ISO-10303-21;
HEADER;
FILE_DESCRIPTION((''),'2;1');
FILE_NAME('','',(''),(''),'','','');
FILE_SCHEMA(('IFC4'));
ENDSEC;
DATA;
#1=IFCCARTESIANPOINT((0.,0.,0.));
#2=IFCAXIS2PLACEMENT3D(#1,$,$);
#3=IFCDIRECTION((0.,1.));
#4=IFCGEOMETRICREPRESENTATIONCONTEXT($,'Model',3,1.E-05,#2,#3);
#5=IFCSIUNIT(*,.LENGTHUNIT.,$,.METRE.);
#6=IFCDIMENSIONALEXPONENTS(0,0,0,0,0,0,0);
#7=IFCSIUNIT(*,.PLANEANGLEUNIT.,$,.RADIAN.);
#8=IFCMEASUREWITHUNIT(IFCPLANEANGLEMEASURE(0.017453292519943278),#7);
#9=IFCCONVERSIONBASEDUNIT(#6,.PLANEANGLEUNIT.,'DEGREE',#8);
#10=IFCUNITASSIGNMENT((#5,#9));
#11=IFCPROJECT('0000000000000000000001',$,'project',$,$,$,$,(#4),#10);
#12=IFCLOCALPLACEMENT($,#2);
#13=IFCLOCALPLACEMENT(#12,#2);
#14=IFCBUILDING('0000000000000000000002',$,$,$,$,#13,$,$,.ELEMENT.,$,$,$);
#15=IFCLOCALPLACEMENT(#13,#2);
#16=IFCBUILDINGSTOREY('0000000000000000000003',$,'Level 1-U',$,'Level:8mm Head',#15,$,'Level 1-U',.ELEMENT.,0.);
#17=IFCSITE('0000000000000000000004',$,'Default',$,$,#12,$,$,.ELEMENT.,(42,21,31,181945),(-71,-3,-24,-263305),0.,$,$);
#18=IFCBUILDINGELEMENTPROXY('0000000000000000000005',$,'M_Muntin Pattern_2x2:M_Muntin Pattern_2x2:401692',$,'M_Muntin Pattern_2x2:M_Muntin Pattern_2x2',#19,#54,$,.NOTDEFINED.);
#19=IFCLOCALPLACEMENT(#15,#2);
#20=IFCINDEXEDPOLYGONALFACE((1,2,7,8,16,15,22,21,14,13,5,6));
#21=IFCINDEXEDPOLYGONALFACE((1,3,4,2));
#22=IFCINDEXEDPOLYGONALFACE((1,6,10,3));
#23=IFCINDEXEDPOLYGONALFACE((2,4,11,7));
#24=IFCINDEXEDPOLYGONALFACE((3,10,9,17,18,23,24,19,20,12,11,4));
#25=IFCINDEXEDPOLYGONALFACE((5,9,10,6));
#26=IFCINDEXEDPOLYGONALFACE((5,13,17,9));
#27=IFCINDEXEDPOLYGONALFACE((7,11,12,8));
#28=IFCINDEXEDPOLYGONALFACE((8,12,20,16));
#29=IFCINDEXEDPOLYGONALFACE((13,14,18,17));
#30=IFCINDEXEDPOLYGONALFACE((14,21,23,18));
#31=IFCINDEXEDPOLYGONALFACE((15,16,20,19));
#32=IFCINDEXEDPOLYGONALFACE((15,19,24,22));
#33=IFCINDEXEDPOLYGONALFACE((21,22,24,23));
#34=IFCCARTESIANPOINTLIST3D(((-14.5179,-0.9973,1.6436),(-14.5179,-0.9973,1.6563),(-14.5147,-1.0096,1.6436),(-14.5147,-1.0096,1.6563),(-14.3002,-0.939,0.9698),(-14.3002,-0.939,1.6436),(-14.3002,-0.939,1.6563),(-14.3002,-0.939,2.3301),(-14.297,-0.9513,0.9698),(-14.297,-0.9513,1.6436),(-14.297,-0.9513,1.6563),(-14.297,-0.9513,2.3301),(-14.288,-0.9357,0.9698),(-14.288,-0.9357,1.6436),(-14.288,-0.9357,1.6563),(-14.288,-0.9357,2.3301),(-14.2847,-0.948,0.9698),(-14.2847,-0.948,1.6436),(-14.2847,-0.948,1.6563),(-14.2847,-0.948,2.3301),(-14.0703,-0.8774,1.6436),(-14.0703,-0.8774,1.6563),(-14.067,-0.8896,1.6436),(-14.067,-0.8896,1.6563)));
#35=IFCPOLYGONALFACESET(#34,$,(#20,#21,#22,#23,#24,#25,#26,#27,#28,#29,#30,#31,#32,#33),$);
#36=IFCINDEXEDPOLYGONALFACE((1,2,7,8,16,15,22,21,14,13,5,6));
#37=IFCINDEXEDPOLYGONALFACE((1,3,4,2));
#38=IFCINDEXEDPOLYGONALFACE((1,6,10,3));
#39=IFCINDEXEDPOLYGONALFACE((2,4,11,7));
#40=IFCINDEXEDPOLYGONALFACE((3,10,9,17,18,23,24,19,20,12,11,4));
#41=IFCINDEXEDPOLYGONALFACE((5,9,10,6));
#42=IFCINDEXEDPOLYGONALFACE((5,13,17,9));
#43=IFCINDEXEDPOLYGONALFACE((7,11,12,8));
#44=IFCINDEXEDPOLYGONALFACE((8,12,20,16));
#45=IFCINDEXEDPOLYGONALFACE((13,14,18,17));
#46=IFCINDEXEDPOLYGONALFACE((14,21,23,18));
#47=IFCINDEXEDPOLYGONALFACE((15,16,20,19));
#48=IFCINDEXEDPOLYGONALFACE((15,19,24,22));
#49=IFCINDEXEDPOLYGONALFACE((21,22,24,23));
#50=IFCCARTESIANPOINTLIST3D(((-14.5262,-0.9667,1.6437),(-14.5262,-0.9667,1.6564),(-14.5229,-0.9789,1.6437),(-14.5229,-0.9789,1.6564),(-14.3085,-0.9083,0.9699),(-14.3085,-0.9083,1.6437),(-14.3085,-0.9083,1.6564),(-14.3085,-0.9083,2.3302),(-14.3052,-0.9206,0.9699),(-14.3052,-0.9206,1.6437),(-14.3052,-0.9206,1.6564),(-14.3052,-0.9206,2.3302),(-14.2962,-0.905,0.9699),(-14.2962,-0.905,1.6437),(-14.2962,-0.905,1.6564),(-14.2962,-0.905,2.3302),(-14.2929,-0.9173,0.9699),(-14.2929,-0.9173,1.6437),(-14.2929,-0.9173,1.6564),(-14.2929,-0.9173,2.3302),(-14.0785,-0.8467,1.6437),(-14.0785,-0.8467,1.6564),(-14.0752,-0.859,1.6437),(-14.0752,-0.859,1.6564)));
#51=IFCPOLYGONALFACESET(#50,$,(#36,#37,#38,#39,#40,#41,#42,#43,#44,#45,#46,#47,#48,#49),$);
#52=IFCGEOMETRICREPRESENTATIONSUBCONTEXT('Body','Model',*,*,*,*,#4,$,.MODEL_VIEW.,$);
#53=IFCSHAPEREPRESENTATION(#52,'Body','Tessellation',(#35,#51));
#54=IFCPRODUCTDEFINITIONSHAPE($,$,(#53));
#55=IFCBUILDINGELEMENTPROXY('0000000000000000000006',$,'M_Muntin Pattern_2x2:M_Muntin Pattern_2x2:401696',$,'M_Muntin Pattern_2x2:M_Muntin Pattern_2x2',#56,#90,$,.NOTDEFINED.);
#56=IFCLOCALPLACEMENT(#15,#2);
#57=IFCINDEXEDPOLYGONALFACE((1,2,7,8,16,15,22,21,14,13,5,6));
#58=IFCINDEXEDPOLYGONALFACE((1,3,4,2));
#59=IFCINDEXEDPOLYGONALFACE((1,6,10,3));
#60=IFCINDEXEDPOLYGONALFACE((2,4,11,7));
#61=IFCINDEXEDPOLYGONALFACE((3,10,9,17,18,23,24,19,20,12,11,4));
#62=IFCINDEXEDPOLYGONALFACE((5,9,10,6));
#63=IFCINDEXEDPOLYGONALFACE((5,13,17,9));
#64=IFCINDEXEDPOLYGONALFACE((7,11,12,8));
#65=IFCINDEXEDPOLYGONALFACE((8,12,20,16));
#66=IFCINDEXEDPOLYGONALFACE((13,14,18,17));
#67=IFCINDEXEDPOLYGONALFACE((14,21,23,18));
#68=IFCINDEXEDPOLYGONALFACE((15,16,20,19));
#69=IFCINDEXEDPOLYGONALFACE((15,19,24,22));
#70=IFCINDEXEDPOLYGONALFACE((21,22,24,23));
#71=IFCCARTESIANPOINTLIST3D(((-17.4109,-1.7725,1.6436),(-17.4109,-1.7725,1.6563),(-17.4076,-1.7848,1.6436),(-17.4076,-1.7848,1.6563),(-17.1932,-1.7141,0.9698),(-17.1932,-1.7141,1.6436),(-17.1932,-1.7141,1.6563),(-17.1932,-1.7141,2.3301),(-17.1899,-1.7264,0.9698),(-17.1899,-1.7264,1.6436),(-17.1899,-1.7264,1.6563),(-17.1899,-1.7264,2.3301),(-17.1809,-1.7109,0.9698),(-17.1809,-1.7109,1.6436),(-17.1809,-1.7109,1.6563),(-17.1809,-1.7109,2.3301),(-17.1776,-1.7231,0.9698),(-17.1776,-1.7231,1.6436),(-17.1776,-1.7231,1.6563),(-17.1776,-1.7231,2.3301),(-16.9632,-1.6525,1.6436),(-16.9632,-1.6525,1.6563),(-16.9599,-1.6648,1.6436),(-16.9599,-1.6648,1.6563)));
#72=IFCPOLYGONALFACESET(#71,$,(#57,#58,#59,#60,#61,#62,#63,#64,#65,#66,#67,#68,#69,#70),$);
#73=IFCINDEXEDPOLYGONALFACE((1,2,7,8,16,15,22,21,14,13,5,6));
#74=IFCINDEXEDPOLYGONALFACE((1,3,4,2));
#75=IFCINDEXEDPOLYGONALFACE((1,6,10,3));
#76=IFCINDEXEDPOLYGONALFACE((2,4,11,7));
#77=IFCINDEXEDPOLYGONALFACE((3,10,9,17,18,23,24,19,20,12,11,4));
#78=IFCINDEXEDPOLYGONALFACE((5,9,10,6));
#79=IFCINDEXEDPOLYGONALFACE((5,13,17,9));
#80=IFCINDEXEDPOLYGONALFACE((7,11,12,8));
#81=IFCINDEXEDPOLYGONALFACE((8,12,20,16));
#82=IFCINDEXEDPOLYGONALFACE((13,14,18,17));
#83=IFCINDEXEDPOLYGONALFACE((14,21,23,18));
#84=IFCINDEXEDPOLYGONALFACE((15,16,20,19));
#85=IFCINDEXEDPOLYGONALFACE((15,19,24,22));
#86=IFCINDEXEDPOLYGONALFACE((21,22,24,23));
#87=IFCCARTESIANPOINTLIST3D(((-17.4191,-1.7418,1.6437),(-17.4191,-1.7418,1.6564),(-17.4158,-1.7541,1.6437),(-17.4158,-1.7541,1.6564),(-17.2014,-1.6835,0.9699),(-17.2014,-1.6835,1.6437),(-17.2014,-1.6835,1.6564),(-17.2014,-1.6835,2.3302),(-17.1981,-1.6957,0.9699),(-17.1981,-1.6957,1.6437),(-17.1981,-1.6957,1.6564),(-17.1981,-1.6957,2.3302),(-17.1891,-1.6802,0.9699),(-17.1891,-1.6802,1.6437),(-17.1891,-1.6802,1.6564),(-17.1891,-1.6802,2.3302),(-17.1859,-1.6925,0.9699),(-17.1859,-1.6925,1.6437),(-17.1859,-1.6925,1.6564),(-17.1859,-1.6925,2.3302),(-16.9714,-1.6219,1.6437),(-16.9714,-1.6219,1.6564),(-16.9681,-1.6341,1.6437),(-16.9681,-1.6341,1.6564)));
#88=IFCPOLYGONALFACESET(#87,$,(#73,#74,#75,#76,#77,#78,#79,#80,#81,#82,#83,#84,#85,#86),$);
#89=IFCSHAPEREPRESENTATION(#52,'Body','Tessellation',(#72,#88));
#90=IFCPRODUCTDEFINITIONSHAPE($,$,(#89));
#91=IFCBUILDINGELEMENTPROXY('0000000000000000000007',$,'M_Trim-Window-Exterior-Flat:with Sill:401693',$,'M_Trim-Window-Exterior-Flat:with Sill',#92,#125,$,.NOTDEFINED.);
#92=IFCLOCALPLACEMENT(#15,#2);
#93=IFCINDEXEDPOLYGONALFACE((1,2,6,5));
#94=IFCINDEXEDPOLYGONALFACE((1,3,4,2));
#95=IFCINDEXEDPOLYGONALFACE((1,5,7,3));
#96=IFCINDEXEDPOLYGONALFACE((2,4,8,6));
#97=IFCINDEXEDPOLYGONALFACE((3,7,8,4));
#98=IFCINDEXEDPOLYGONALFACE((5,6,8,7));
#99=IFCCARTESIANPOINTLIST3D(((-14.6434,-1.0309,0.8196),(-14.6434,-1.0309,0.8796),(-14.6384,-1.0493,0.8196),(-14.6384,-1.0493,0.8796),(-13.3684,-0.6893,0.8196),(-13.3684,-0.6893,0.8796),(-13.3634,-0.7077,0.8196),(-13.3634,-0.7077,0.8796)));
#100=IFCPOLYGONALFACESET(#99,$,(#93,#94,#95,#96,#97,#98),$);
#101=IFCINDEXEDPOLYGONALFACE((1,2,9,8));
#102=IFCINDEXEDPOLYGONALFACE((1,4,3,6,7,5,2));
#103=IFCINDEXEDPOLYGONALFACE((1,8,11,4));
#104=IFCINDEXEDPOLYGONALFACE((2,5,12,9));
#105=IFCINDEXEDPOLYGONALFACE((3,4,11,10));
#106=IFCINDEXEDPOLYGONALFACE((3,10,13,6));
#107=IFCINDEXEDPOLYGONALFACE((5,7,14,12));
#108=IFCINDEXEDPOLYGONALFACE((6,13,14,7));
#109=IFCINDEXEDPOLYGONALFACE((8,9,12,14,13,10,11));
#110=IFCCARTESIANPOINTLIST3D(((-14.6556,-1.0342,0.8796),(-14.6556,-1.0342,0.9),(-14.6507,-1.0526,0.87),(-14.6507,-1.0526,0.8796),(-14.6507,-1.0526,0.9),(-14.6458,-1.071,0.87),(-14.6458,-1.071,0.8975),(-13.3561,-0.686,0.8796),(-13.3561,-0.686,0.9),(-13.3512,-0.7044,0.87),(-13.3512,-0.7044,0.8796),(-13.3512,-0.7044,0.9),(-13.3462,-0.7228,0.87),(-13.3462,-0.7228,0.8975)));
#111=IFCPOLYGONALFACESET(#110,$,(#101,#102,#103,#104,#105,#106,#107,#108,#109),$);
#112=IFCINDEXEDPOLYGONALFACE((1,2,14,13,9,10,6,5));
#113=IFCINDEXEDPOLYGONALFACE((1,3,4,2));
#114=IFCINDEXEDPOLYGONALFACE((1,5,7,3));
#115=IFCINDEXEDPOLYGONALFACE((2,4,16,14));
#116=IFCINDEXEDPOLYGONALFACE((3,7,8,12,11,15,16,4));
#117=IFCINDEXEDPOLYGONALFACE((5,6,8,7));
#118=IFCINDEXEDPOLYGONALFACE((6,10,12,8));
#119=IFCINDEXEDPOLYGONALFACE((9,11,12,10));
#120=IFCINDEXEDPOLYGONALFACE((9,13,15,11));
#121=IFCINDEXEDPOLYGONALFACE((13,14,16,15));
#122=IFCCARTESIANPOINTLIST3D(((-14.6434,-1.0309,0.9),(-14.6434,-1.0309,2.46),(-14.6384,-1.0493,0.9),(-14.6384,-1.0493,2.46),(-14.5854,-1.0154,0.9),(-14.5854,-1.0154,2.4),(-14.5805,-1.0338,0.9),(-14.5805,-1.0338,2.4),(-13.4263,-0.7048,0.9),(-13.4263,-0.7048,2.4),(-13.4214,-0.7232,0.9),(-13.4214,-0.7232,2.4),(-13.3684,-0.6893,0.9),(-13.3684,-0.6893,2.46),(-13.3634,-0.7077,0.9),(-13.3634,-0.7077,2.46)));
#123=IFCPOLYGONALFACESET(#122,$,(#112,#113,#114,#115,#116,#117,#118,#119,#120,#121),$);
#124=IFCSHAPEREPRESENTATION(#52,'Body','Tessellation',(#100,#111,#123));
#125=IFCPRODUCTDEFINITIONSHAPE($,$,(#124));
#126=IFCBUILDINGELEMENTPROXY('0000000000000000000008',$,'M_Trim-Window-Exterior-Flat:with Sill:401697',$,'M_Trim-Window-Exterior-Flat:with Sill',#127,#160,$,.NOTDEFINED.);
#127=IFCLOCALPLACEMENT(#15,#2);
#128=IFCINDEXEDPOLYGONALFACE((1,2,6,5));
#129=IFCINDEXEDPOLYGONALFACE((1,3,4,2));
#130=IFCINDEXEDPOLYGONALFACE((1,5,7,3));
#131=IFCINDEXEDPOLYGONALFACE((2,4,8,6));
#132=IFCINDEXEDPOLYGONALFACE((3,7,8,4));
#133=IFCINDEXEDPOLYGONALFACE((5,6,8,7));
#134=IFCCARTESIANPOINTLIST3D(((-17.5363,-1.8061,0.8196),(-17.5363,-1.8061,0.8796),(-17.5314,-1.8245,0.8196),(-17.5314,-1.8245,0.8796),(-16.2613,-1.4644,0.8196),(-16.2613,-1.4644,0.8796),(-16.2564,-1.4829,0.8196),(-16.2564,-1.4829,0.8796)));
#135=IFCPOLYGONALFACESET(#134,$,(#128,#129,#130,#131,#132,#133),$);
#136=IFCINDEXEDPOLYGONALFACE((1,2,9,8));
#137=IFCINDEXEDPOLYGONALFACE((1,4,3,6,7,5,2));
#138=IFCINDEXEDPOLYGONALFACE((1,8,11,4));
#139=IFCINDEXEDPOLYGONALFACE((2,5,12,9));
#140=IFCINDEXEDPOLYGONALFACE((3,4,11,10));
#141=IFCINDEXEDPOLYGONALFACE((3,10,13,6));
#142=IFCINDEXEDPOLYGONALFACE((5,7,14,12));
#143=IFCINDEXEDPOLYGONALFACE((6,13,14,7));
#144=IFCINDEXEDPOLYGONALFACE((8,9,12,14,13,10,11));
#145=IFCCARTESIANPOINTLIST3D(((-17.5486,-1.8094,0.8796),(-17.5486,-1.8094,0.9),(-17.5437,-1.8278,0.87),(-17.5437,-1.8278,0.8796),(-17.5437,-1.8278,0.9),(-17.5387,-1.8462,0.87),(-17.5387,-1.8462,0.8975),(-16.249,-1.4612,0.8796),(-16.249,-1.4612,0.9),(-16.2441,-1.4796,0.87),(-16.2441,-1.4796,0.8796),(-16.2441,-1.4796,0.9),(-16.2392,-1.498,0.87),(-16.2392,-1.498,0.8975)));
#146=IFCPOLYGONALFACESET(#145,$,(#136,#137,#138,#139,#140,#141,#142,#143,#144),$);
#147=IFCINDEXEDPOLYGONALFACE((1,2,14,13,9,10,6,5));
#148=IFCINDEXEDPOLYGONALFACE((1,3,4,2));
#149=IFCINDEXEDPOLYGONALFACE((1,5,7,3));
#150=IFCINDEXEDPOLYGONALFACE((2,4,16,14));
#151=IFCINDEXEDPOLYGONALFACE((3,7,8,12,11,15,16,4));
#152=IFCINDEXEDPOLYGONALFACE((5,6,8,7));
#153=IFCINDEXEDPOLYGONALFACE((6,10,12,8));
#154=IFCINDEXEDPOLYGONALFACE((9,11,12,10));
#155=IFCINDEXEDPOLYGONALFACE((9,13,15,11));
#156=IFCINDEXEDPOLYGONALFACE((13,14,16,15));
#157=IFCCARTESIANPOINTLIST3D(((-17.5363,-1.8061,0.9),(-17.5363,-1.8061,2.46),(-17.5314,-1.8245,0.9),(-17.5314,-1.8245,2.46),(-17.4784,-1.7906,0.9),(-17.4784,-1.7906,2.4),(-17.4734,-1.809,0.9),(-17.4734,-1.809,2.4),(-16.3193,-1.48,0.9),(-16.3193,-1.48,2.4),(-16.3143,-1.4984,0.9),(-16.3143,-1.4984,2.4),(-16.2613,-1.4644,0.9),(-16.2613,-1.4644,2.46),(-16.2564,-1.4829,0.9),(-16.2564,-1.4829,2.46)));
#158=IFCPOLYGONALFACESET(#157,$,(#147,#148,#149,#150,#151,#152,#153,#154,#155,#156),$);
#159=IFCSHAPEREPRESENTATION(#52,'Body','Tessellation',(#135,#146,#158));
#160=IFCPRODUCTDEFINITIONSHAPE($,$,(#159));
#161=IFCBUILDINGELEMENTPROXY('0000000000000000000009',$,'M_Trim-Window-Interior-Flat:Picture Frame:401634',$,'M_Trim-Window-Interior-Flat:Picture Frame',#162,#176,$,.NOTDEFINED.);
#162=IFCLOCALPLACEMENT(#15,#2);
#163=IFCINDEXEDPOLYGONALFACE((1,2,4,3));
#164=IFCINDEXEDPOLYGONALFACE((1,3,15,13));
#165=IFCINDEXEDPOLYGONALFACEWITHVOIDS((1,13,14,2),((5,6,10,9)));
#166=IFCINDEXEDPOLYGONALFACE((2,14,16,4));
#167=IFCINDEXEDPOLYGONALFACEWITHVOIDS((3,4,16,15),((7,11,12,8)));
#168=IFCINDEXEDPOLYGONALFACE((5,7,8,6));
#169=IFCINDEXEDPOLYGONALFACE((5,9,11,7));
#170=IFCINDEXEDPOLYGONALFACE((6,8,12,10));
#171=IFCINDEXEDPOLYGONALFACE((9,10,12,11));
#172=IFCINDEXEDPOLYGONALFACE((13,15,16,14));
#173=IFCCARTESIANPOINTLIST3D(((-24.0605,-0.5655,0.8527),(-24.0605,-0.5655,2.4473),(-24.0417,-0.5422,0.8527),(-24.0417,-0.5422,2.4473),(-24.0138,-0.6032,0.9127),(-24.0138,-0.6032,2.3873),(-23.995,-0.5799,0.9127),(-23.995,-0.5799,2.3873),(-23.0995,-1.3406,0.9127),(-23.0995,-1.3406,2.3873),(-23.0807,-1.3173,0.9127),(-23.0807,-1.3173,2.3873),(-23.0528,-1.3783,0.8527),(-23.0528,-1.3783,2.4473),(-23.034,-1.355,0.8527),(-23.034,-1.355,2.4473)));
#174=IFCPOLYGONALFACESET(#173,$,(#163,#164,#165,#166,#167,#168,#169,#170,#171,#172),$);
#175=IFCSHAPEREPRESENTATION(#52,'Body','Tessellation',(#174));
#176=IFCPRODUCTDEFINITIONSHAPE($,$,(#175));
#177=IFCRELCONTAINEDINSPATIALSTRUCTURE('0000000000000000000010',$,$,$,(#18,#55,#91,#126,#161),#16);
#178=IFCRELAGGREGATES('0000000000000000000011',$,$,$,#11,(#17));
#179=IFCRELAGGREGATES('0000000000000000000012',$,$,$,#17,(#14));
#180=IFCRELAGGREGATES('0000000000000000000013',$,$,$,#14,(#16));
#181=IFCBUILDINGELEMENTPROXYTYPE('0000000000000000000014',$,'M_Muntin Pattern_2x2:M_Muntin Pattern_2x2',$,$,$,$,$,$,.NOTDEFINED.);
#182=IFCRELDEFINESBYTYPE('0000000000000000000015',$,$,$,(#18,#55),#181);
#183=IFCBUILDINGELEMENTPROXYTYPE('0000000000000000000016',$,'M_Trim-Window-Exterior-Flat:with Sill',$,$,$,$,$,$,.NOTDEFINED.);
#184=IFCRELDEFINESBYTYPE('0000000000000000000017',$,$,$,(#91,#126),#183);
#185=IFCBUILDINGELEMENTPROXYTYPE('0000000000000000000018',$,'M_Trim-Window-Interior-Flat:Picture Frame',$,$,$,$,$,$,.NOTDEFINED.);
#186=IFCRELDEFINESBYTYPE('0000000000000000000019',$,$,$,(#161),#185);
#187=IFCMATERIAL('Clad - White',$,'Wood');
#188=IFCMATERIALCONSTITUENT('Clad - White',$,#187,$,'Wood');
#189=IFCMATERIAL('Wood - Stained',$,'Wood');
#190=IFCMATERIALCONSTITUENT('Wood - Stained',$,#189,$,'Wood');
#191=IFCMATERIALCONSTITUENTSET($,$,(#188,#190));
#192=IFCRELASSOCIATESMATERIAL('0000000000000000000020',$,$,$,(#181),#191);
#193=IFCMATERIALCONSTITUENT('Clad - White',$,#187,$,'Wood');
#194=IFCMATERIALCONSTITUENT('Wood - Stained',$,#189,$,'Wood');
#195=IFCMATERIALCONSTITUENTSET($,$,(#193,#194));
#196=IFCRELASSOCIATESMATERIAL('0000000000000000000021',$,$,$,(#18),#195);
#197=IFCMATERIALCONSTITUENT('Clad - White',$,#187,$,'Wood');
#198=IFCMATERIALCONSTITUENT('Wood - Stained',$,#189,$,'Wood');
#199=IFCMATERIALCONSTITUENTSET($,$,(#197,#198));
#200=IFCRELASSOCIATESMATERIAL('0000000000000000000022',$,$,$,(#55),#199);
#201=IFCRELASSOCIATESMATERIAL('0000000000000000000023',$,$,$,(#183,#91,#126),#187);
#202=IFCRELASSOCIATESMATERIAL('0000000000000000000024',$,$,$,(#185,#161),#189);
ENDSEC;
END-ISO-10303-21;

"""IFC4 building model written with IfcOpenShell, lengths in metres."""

from ifc_helpers import new_model, entity, si_unit, converted_unit, direction, frame, frame_2d, origin, place, context, subcontext, project, spatial, polyline, rectangle, outline, extrude, source, transform, mapped, material, constituent, constituent_set, type_object, type_shapes, element, save


model = new_model("IFC4")

# Units and contexts
model_context = context("Model", 3, precision=1e-05, world=origin(), true_north=direction((0.0, 1.0)))
body_context = subcontext(model_context, "Body", "Model", "MODEL_VIEW")
ifc_project = project(units=[si_unit("LENGTHUNIT", "METRE"), converted_unit("PLANEANGLEUNIT", "DEGREE", entity("IfcPlaneAngleMeasure", 0.017453292519943278), si_unit("PLANEANGLEUNIT", "RADIAN"), dimensions=[0, 0, 0, 0, 0, 0, 0])], contexts=[model_context])

# Site, building, storey
site_placement = place(None, origin())
site = spatial("IfcSite", under=ifc_project, at=site_placement, Name="Default", CompositionType="ELEMENT", RefLatitude=(42, 21, 31, 181945), RefLongitude=(-71, -3, -24, -263305), RefElevation=0.0)
building_placement = place(site_placement, origin())
building = spatial("IfcBuilding", under=site, at=building_placement, CompositionType="ELEMENT")
storey_placement = place(building_placement, origin())
storey = spatial("IfcBuildingStorey", under=building, at=storey_placement, Name="Level 1-U", ObjectType="Level:8mm Head", LongName="Level 1-U", CompositionType="ELEMENT", Elevation=0.0)

# Building element proxies
ifc_material_1 = material(Name="Clad - White", Category="Wood")
ifc_material_2 = material(Name="Wood - Stained", Category="Wood")
ifc_constituent_1 = constituent(ifc_material_1, Name="Clad - White", Category="Wood")
ifc_constituent_2 = constituent(ifc_material_2, Name="Wood - Stained", Category="Wood")
ifc_constituent_set_1 = constituent_set(constituents=[ifc_constituent_1, ifc_constituent_2])
ifc_constituent_3 = constituent(ifc_material_1, Name="Clad - White", Category="Wood")
ifc_constituent_4 = constituent(ifc_material_2, Name="Wood - Stained", Category="Wood")
ifc_constituent_set_2 = constituent_set(constituents=[ifc_constituent_3, ifc_constituent_4])
building_element_proxy_type_1 = type_object("IfcBuildingElementProxyType", Name="M_Muntin Pattern_2x2:M_Muntin Pattern_2x2", PredefinedType="NOTDEFINED", material=ifc_constituent_set_2)
shared_shape_1 = source(origin(), body_context, "Body", "SweptSolid", [
    extrude(outline(polyline([(0.0064, -0.0064), (0.6801, -0.0064), (0.6801, 0.0063), (0.0064, 0.0063), (0.0064, 0.2317), (-0.0063, 0.2317), (-0.0063, 0.0063), (-0.6802, 0.0063), (-0.6802, -0.0064), (-0.0063, -0.0064), (-0.0063, -0.2317), (0.0064, -0.2317), (0.0064, -0.0064)])), frame((0.0, -0.0222, 0.6801), z_axis=(0.0, 1.0, 0.0), x_axis=(0.0, 0.0, 1.0)), (0.0, 0.0, 1.0), 0.0127),
    extrude(outline(polyline([(0.0064, -0.0064), (0.6802, -0.0064), (0.6802, 0.0063), (0.0064, 0.0063), (0.0064, 0.2317), (-0.0063, 0.2317), (-0.0063, 0.0063), (-0.6802, 0.0063), (-0.6802, -0.0064), (-0.0063, -0.0064), (-0.0063, -0.2317), (0.0064, -0.2317), (0.0064, -0.0064)])), frame((0.0, 0.0095, 0.6802), z_axis=(0.0, 1.0, 0.0), x_axis=(0.0, 0.0, 1.0)), (0.0, 0.0, 1.0), 0.0127),
])
type_shapes(building_element_proxy_type_1, [shared_shape_1])
proxy_1_placement = place(storey_placement, frame((-14.2966, -0.9281, 0.9699), z_axis=(0.0, 0.0, 1.0), x_axis=(0.965926, 0.258819, 0.0)))
element("IfcBuildingElementProxy", 1, at=proxy_1_placement, inside=storey, type_object=building_element_proxy_type_1, material=ifc_constituent_set_1, Name="M_Muntin Pattern_2x2:M_Muntin Pattern_2x2:401692", ObjectType="M_Muntin Pattern_2x2:M_Muntin Pattern_2x2", PredefinedType="NOTDEFINED", context=body_context, shape_type="MappedRepresentation", body=[
    mapped(shared_shape_1, transform((0.0, 0.0, 0.0), scale=1.0)),
])
ifc_constituent_5 = constituent(ifc_material_1, Name="Clad - White", Category="Wood")
ifc_constituent_6 = constituent(ifc_material_2, Name="Wood - Stained", Category="Wood")
ifc_constituent_set_3 = constituent_set(constituents=[ifc_constituent_5, ifc_constituent_6])
proxy_2_placement = place(storey_placement, frame((-17.1895, -1.7033, 0.9699), z_axis=(0.0, 0.0, 1.0), x_axis=(0.965926, 0.258819, 0.0)))
element("IfcBuildingElementProxy", 2, at=proxy_2_placement, inside=storey, type_object=building_element_proxy_type_1, material=ifc_constituent_set_3, Name="M_Muntin Pattern_2x2:M_Muntin Pattern_2x2:401696", ObjectType="M_Muntin Pattern_2x2:M_Muntin Pattern_2x2", PredefinedType="NOTDEFINED", context=body_context, shape_type="MappedRepresentation", body=[
    mapped(shared_shape_1, transform((0.0, 0.0, 0.0), scale=1.0)),
])
building_element_proxy_type_2 = type_object("IfcBuildingElementProxyType", Name="M_Trim-Window-Exterior-Flat:with Sill", PredefinedType="NOTDEFINED", material=ifc_material_1)
shared_shape_2 = source(origin(), body_context, "Body", "SweptSolid", [
    extrude(rectangle(XDim=1.32, YDim=0.06, at=frame_2d((0.0, 0.0), x_axis=(1.0, 0.0))), frame((0.0, -1.5504, 0.0), z_axis=(0.0, 0.0, 1.0), x_axis=(-1.0, 0.0, 0.0)), (0.0, 0.0, 1.0), 0.019),
    extrude(outline(polyline([(-0.019, -0.0152), (0.0, -0.0152), (0.0, -0.0057), (0.019, -0.0057), (0.019, 0.0148), (0.0, 0.0148), (-0.019, 0.0123), (-0.019, -0.0152)])), frame((-0.6727, -1.5148, 0.019), z_axis=(1.0, 0.0, 0.0), x_axis=(0.0, 0.0, -1.0)), (0.0, 0.0, 1.0), 1.3454),
    extrude(outline(polyline([(-0.795, -0.66), (0.765, -0.66), (0.765, -0.6), (-0.735, -0.6), (-0.735, 0.6), (0.765, 0.6), (0.765, 0.66), (-0.795, 0.66), (-0.795, -0.66)])), frame((0.0, -0.735, 0.0), z_axis=(0.0, 0.0, 1.0), x_axis=(0.0, -1.0, 0.0)), (0.0, 0.0, 1.0), 0.019),
])
type_shapes(building_element_proxy_type_2, [shared_shape_2])
for number, where, z_axis, x_axis, name in (
    (3, (-14.0059, -0.8601, 2.4), (0.258819, -0.965926, 0.0), (0.965926, 0.258819, 0.0), "M_Trim-Window-Exterior-Flat:with Sill:401693"),
    (4, (-16.8988, -1.6353, 2.4), (0.258819, -0.965926, 0.0), (0.965926, 0.258819, 0.0), "M_Trim-Window-Exterior-Flat:with Sill:401697"),
):
    element("IfcBuildingElementProxy", number, at=place(storey_placement, frame(where, z_axis=z_axis, x_axis=x_axis)), inside=storey, type_object=building_element_proxy_type_2, material=ifc_material_1, Name=name, ObjectType="M_Trim-Window-Exterior-Flat:with Sill", PredefinedType="NOTDEFINED", context=body_context, shape_type="MappedRepresentation", body=[
        mapped(shared_shape_2, transform((0.0, 0.0, 0.0), scale=1.0)),
    ])
building_element_proxy_type_3 = type_object("IfcBuildingElementProxyType", Name="M_Trim-Window-Interior-Flat:Picture Frame", PredefinedType="NOTDEFINED", material=ifc_material_2)
shared_shape_3 = source(origin(), body_context, "Body", "SweptSolid", [
    extrude(outline(polyline([(-0.6473, -0.7973), (0.6473, -0.7973), (0.6473, 0.7973), (-0.6473, 0.7973), (-0.6473, -0.7973)]), holes=[polyline([(-0.5873, -0.7373), (-0.5873, 0.7373), (0.5873, 0.7373), (0.5873, -0.7373), (-0.5873, -0.7373)])]), frame((0.0, -0.75, 0.0), z_axis=(0.0, 0.0, 1.0), x_axis=(-1.0, 0.0, 0.0)), (0.0, 0.0, 1.0), 0.03),
])
type_shapes(building_element_proxy_type_3, [shared_shape_3])
for number, where, z_axis, x_axis, name in (
    (5, (-23.5567, -0.9719, 2.4), (0.62782, 0.778359, 0.0), (-0.778359, 0.62782, 0.0), "M_Trim-Window-Interior-Flat:Picture Frame:401634"),
):
    element("IfcBuildingElementProxy", number, at=place(storey_placement, frame(where, z_axis=z_axis, x_axis=x_axis)), inside=storey, type_object=building_element_proxy_type_3, material=ifc_material_2, Name=name, ObjectType="M_Trim-Window-Interior-Flat:Picture Frame", PredefinedType="NOTDEFINED", context=body_context, shape_type="MappedRepresentation", body=[
        mapped(shared_shape_3, transform((0.0, 0.0, 0.0), scale=1.0)),
    ])

save(model, "model.ifc")
